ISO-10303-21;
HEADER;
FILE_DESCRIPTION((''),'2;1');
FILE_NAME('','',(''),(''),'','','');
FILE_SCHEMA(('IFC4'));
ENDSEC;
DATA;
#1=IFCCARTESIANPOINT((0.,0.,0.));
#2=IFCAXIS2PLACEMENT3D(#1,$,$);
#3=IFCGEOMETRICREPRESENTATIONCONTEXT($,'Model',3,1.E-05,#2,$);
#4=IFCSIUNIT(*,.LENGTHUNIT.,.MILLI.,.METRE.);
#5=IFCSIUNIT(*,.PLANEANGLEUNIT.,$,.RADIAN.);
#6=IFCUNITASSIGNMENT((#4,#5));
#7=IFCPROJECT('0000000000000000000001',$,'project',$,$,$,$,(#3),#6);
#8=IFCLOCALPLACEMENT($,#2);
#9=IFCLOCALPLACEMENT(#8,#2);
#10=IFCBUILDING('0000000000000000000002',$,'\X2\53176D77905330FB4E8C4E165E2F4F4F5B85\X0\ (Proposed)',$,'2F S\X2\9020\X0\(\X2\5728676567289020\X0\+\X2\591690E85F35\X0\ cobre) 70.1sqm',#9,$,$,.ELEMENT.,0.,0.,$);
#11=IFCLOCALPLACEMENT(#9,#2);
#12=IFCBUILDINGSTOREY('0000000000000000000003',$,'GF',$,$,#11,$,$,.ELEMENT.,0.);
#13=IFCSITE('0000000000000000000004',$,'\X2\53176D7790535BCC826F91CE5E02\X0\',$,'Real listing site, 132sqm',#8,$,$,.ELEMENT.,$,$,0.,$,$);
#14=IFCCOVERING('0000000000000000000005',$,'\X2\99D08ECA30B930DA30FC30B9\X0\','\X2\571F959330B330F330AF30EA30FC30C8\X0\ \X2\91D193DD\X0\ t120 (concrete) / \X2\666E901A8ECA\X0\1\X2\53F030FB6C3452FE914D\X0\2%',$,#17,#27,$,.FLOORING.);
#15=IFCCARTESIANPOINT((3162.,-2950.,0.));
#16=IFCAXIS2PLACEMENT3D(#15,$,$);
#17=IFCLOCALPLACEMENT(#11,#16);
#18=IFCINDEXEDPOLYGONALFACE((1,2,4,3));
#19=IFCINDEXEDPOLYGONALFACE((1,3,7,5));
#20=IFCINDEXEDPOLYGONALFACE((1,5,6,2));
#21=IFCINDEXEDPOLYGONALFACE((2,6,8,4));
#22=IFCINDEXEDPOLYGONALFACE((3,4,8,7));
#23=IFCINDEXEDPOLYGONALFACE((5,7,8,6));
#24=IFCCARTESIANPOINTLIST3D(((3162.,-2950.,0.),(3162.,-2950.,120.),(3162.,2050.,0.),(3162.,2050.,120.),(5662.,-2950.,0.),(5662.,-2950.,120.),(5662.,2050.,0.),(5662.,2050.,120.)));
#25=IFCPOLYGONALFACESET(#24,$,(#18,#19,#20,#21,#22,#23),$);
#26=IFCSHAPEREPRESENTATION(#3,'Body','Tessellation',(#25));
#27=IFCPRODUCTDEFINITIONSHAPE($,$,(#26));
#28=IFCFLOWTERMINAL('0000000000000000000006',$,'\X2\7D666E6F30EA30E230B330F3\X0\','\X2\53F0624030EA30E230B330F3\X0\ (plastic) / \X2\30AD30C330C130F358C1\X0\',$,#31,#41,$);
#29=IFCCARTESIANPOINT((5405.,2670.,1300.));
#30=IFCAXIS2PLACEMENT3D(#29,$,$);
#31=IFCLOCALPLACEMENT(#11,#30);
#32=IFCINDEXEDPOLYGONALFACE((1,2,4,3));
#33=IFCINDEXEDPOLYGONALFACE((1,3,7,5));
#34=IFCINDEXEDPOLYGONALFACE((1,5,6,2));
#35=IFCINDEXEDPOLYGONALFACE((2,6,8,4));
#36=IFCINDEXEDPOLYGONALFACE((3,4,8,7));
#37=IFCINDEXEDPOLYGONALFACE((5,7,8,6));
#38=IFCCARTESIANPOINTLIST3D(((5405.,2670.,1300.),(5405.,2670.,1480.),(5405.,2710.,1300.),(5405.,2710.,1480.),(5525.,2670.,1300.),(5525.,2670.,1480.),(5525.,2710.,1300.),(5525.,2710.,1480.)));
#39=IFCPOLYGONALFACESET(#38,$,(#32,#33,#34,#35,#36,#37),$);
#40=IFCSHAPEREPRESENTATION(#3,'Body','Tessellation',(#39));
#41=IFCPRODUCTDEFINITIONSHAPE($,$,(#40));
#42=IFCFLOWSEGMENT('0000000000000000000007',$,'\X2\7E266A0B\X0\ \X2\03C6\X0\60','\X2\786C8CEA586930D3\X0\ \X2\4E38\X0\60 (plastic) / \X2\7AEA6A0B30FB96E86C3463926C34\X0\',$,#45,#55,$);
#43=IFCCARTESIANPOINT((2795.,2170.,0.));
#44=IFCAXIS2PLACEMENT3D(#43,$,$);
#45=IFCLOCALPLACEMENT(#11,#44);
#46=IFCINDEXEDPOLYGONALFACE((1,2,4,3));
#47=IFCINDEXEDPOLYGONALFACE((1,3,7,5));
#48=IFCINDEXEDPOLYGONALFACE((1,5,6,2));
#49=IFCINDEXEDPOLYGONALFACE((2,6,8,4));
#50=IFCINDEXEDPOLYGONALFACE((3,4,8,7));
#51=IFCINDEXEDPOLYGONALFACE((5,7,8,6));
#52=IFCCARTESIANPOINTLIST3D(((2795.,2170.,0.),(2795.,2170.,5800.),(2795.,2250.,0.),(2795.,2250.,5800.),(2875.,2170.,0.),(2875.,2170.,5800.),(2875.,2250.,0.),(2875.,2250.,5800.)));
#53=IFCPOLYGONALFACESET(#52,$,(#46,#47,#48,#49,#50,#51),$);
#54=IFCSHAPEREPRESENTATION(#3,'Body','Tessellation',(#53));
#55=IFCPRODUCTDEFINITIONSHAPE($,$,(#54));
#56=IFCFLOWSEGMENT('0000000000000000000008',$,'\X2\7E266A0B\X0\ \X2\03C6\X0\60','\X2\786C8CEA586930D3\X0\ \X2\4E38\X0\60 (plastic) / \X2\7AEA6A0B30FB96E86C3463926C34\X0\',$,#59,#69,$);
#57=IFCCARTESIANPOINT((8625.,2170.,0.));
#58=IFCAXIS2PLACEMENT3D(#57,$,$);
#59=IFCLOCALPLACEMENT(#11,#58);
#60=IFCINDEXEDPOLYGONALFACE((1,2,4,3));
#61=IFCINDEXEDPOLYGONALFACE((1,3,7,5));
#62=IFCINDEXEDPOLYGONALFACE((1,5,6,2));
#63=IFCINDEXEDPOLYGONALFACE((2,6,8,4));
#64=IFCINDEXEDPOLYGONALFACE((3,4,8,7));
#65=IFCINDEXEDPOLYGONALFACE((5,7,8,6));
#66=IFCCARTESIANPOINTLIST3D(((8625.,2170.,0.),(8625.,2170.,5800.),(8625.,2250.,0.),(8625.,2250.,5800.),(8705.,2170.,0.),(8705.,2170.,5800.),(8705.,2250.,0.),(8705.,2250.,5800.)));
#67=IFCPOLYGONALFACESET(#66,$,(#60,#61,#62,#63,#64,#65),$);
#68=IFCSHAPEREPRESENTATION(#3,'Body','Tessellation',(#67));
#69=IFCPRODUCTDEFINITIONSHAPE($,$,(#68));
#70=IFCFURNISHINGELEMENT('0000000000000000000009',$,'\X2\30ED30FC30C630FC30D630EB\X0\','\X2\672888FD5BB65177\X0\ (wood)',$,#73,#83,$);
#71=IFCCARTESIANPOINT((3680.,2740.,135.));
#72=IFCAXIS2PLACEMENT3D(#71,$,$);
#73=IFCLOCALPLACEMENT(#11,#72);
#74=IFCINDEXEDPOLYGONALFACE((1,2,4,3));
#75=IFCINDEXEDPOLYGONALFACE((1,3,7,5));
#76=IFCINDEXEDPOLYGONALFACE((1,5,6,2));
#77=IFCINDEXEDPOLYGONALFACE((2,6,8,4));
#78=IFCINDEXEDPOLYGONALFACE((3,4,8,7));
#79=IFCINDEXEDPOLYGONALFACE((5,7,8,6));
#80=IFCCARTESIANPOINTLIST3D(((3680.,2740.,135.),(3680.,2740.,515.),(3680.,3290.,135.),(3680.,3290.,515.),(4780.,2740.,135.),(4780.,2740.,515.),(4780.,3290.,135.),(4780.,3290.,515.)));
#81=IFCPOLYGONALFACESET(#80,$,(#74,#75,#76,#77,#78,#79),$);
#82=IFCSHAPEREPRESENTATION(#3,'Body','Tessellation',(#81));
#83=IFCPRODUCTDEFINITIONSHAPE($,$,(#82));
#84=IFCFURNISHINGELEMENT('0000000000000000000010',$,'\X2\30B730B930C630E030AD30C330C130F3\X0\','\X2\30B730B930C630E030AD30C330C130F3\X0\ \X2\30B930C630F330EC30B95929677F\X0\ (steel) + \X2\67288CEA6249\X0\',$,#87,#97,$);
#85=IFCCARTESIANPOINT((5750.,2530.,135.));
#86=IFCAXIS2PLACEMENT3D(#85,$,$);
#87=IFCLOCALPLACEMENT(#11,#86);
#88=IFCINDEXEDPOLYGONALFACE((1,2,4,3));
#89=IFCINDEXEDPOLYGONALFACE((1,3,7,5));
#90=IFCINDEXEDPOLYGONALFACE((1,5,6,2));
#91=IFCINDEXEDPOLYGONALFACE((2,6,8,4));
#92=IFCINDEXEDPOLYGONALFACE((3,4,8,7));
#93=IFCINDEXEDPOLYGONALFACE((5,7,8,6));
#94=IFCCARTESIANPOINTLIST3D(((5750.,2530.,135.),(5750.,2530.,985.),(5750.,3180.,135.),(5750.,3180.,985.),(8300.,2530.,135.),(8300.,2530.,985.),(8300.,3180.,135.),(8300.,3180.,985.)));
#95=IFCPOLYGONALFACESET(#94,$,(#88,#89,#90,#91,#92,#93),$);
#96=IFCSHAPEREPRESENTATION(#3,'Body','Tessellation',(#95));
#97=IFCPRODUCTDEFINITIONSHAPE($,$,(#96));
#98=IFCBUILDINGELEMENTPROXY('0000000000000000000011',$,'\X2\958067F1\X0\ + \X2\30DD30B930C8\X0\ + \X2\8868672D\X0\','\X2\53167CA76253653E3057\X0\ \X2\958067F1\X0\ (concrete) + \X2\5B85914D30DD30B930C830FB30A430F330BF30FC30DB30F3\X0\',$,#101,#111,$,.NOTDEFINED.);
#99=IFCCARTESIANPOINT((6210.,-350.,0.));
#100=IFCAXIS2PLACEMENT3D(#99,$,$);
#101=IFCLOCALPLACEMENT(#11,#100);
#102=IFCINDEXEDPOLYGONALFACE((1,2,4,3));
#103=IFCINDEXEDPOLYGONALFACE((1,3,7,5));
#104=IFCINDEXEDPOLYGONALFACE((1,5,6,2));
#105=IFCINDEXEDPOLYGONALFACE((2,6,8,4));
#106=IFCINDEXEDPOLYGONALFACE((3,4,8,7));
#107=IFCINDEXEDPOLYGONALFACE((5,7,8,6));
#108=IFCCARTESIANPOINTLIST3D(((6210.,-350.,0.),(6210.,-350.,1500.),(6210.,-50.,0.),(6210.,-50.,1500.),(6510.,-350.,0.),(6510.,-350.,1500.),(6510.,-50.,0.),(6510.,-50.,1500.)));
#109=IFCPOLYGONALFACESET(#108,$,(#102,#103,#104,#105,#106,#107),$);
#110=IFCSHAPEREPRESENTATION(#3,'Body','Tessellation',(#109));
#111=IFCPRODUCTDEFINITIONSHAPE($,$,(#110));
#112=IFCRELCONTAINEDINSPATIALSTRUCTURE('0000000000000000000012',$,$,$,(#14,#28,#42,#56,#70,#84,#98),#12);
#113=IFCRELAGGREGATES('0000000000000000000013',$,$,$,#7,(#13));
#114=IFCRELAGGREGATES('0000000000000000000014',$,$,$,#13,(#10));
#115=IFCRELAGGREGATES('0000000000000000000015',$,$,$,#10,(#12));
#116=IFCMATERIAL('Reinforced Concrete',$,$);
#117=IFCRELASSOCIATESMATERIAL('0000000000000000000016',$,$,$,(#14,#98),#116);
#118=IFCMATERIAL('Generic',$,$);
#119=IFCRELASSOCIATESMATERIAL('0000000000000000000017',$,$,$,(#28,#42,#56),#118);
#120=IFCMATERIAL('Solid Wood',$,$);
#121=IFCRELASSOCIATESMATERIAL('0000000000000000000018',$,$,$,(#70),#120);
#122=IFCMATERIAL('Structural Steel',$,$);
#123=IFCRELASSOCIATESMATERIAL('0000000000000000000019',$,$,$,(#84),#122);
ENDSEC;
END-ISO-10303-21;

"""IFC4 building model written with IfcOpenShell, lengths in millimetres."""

from ifc_helpers import new_model, si_unit, frame, frame_2d, origin, place, context, project, spatial, rectangle, extrude, material, element, save


model = new_model("IFC4")

# Units and contexts
model_context = context("Model", 3, precision=1e-05, world=origin())
ifc_project = project(units=[si_unit("LENGTHUNIT", "METRE", prefix="MILLI"), si_unit("PLANEANGLEUNIT", "RADIAN")], contexts=[model_context])

# Site, building, storey
site_placement = place(None, origin())
site = spatial("IfcSite", under=ifc_project, at=site_placement, Name="北海道富良野市", ObjectType="Real listing site, 132sqm", CompositionType="ELEMENT", RefElevation=0.0)
building_placement = place(site_placement, origin())
building = spatial("IfcBuilding", under=site, at=building_placement, Name="北海道・二世帯住宅 (Proposed)", ObjectType="2F S造(在来木造+外部張 cobre) 70.1sqm", CompositionType="ELEMENT", ElevationOfRefHeight=0.0, ElevationOfTerrain=0.0)
storey_placement = place(building_placement, origin())
storey = spatial("IfcBuildingStorey", under=building, at=storey_placement, Name="GF", CompositionType="ELEMENT", Elevation=0.0)

# Shared definitions
ifc_material_1 = material(Name="Solid Wood")

# Shared definitions
ifc_material_2 = material(Name="Reinforced Concrete")

# Covering
ifc_material_3 = material(Name="Generic")
covering_1_placement = place(storey_placement, frame((3162.0, -2950.0, 0.0)))
element("IfcCovering", 1, at=covering_1_placement, inside=storey, material=ifc_material_2, Name="駐車スペース", Description="土間コンクリート 金鏝 t120 (concrete) / 普通車1台・水勾配2%", PredefinedType="FLOORING", context=model_context, shape_type="SweptSolid", body=[
    extrude(rectangle(XDim=2500.0, YDim=5000.0, at=frame_2d((1250.0, 2500.0))), frame((3162.0, -2950.0, 0.0)), (0.0, 0.0, 1.0), 120.0),
])

# Flow terminal
flow_terminal_placement = place(storey_placement, frame((5405.0, 2670.0, 1300.0)))
element("IfcFlowTerminal", 2, at=flow_terminal_placement, inside=storey, material=ifc_material_3, Name="給湯リモコン", Description="台所リモコン (plastic) / キッチン壁", context=model_context, shape_type="SweptSolid", body=[
    extrude(rectangle(XDim=120.0, YDim=40.0, at=frame_2d((60.0, 20.0))), frame((5405.0, 2670.0, 1300.0)), (0.0, 0.0, 1.0), 180.0),
])

# Flow segments
flow_segment_1_placement = place(storey_placement, frame((2795.0, 2170.0, 0.0)))
element("IfcFlowSegment", 3, at=flow_segment_1_placement, inside=storey, material=ifc_material_3, Name="縦樋 φ60", Description="硬質塩ビ 丸60 (plastic) / 竪樋・雨水排水", context=model_context, shape_type="SweptSolid", body=[
    extrude(rectangle(XDim=80.0, YDim=80.0, at=frame_2d((40.0, 40.0))), frame((2795.0, 2170.0, 0.0)), (0.0, 0.0, 1.0), 5800.0),
])
flow_segment_2_placement = place(storey_placement, frame((8625.0, 2170.0, 0.0)))
element("IfcFlowSegment", 4, at=flow_segment_2_placement, inside=storey, material=ifc_material_3, Name="縦樋 φ60", Description="硬質塩ビ 丸60 (plastic) / 竪樋・雨水排水", context=model_context, shape_type="SweptSolid", body=[
    extrude(rectangle(XDim=80.0, YDim=80.0, at=frame_2d((40.0, 40.0))), frame((8625.0, 2170.0, 0.0)), (0.0, 0.0, 1.0), 5800.0),
])

# Furnishing elements
furnishing_1_placement = place(storey_placement, frame((3680.0, 2740.0, 135.0)))
element("IfcFurnishingElement", 5, at=furnishing_1_placement, inside=storey, material=ifc_material_1, Name="ローテーブル", Description="木製家具 (wood)", context=model_context, shape_type="SweptSolid", body=[
    extrude(rectangle(XDim=1100.0, YDim=550.0, at=frame_2d((550.0, 275.0))), frame((3680.0, 2740.0, 135.0)), (0.0, 0.0, 1.0), 380.0),
])
ifc_material_4 = material(Name="Structural Steel")
furnishing_2_placement = place(storey_placement, frame((5750.0, 2530.0, 135.0)))
element("IfcFurnishingElement", 6, at=furnishing_2_placement, inside=storey, material=ifc_material_4, Name="システムキッチン", Description="システムキッチン ステンレス天板 (steel) + 木質扉", context=model_context, shape_type="SweptSolid", body=[
    extrude(rectangle(XDim=2550.0, YDim=650.0, at=frame_2d((1275.0, 325.0))), frame((5750.0, 2530.0, 135.0)), (0.0, 0.0, 1.0), 850.0),
])

# Building element proxy
proxy_placement = place(storey_placement, frame((6210.0, -350.0, 0.0)))
element("IfcBuildingElementProxy", 7, at=proxy_placement, inside=storey, material=ifc_material_2, Name="門柱 + ポスト + 表札", Description="化粧打放し 門柱 (concrete) + 宅配ポスト・インターホン", PredefinedType="NOTDEFINED", context=model_context, shape_type="SweptSolid", body=[
    extrude(rectangle(XDim=300.0, YDim=300.0, at=frame_2d((150.0, 150.0))), frame((6210.0, -350.0, 0.0)), (0.0, 0.0, 1.0), 1500.0),
])

save(model, "model.ifc")
